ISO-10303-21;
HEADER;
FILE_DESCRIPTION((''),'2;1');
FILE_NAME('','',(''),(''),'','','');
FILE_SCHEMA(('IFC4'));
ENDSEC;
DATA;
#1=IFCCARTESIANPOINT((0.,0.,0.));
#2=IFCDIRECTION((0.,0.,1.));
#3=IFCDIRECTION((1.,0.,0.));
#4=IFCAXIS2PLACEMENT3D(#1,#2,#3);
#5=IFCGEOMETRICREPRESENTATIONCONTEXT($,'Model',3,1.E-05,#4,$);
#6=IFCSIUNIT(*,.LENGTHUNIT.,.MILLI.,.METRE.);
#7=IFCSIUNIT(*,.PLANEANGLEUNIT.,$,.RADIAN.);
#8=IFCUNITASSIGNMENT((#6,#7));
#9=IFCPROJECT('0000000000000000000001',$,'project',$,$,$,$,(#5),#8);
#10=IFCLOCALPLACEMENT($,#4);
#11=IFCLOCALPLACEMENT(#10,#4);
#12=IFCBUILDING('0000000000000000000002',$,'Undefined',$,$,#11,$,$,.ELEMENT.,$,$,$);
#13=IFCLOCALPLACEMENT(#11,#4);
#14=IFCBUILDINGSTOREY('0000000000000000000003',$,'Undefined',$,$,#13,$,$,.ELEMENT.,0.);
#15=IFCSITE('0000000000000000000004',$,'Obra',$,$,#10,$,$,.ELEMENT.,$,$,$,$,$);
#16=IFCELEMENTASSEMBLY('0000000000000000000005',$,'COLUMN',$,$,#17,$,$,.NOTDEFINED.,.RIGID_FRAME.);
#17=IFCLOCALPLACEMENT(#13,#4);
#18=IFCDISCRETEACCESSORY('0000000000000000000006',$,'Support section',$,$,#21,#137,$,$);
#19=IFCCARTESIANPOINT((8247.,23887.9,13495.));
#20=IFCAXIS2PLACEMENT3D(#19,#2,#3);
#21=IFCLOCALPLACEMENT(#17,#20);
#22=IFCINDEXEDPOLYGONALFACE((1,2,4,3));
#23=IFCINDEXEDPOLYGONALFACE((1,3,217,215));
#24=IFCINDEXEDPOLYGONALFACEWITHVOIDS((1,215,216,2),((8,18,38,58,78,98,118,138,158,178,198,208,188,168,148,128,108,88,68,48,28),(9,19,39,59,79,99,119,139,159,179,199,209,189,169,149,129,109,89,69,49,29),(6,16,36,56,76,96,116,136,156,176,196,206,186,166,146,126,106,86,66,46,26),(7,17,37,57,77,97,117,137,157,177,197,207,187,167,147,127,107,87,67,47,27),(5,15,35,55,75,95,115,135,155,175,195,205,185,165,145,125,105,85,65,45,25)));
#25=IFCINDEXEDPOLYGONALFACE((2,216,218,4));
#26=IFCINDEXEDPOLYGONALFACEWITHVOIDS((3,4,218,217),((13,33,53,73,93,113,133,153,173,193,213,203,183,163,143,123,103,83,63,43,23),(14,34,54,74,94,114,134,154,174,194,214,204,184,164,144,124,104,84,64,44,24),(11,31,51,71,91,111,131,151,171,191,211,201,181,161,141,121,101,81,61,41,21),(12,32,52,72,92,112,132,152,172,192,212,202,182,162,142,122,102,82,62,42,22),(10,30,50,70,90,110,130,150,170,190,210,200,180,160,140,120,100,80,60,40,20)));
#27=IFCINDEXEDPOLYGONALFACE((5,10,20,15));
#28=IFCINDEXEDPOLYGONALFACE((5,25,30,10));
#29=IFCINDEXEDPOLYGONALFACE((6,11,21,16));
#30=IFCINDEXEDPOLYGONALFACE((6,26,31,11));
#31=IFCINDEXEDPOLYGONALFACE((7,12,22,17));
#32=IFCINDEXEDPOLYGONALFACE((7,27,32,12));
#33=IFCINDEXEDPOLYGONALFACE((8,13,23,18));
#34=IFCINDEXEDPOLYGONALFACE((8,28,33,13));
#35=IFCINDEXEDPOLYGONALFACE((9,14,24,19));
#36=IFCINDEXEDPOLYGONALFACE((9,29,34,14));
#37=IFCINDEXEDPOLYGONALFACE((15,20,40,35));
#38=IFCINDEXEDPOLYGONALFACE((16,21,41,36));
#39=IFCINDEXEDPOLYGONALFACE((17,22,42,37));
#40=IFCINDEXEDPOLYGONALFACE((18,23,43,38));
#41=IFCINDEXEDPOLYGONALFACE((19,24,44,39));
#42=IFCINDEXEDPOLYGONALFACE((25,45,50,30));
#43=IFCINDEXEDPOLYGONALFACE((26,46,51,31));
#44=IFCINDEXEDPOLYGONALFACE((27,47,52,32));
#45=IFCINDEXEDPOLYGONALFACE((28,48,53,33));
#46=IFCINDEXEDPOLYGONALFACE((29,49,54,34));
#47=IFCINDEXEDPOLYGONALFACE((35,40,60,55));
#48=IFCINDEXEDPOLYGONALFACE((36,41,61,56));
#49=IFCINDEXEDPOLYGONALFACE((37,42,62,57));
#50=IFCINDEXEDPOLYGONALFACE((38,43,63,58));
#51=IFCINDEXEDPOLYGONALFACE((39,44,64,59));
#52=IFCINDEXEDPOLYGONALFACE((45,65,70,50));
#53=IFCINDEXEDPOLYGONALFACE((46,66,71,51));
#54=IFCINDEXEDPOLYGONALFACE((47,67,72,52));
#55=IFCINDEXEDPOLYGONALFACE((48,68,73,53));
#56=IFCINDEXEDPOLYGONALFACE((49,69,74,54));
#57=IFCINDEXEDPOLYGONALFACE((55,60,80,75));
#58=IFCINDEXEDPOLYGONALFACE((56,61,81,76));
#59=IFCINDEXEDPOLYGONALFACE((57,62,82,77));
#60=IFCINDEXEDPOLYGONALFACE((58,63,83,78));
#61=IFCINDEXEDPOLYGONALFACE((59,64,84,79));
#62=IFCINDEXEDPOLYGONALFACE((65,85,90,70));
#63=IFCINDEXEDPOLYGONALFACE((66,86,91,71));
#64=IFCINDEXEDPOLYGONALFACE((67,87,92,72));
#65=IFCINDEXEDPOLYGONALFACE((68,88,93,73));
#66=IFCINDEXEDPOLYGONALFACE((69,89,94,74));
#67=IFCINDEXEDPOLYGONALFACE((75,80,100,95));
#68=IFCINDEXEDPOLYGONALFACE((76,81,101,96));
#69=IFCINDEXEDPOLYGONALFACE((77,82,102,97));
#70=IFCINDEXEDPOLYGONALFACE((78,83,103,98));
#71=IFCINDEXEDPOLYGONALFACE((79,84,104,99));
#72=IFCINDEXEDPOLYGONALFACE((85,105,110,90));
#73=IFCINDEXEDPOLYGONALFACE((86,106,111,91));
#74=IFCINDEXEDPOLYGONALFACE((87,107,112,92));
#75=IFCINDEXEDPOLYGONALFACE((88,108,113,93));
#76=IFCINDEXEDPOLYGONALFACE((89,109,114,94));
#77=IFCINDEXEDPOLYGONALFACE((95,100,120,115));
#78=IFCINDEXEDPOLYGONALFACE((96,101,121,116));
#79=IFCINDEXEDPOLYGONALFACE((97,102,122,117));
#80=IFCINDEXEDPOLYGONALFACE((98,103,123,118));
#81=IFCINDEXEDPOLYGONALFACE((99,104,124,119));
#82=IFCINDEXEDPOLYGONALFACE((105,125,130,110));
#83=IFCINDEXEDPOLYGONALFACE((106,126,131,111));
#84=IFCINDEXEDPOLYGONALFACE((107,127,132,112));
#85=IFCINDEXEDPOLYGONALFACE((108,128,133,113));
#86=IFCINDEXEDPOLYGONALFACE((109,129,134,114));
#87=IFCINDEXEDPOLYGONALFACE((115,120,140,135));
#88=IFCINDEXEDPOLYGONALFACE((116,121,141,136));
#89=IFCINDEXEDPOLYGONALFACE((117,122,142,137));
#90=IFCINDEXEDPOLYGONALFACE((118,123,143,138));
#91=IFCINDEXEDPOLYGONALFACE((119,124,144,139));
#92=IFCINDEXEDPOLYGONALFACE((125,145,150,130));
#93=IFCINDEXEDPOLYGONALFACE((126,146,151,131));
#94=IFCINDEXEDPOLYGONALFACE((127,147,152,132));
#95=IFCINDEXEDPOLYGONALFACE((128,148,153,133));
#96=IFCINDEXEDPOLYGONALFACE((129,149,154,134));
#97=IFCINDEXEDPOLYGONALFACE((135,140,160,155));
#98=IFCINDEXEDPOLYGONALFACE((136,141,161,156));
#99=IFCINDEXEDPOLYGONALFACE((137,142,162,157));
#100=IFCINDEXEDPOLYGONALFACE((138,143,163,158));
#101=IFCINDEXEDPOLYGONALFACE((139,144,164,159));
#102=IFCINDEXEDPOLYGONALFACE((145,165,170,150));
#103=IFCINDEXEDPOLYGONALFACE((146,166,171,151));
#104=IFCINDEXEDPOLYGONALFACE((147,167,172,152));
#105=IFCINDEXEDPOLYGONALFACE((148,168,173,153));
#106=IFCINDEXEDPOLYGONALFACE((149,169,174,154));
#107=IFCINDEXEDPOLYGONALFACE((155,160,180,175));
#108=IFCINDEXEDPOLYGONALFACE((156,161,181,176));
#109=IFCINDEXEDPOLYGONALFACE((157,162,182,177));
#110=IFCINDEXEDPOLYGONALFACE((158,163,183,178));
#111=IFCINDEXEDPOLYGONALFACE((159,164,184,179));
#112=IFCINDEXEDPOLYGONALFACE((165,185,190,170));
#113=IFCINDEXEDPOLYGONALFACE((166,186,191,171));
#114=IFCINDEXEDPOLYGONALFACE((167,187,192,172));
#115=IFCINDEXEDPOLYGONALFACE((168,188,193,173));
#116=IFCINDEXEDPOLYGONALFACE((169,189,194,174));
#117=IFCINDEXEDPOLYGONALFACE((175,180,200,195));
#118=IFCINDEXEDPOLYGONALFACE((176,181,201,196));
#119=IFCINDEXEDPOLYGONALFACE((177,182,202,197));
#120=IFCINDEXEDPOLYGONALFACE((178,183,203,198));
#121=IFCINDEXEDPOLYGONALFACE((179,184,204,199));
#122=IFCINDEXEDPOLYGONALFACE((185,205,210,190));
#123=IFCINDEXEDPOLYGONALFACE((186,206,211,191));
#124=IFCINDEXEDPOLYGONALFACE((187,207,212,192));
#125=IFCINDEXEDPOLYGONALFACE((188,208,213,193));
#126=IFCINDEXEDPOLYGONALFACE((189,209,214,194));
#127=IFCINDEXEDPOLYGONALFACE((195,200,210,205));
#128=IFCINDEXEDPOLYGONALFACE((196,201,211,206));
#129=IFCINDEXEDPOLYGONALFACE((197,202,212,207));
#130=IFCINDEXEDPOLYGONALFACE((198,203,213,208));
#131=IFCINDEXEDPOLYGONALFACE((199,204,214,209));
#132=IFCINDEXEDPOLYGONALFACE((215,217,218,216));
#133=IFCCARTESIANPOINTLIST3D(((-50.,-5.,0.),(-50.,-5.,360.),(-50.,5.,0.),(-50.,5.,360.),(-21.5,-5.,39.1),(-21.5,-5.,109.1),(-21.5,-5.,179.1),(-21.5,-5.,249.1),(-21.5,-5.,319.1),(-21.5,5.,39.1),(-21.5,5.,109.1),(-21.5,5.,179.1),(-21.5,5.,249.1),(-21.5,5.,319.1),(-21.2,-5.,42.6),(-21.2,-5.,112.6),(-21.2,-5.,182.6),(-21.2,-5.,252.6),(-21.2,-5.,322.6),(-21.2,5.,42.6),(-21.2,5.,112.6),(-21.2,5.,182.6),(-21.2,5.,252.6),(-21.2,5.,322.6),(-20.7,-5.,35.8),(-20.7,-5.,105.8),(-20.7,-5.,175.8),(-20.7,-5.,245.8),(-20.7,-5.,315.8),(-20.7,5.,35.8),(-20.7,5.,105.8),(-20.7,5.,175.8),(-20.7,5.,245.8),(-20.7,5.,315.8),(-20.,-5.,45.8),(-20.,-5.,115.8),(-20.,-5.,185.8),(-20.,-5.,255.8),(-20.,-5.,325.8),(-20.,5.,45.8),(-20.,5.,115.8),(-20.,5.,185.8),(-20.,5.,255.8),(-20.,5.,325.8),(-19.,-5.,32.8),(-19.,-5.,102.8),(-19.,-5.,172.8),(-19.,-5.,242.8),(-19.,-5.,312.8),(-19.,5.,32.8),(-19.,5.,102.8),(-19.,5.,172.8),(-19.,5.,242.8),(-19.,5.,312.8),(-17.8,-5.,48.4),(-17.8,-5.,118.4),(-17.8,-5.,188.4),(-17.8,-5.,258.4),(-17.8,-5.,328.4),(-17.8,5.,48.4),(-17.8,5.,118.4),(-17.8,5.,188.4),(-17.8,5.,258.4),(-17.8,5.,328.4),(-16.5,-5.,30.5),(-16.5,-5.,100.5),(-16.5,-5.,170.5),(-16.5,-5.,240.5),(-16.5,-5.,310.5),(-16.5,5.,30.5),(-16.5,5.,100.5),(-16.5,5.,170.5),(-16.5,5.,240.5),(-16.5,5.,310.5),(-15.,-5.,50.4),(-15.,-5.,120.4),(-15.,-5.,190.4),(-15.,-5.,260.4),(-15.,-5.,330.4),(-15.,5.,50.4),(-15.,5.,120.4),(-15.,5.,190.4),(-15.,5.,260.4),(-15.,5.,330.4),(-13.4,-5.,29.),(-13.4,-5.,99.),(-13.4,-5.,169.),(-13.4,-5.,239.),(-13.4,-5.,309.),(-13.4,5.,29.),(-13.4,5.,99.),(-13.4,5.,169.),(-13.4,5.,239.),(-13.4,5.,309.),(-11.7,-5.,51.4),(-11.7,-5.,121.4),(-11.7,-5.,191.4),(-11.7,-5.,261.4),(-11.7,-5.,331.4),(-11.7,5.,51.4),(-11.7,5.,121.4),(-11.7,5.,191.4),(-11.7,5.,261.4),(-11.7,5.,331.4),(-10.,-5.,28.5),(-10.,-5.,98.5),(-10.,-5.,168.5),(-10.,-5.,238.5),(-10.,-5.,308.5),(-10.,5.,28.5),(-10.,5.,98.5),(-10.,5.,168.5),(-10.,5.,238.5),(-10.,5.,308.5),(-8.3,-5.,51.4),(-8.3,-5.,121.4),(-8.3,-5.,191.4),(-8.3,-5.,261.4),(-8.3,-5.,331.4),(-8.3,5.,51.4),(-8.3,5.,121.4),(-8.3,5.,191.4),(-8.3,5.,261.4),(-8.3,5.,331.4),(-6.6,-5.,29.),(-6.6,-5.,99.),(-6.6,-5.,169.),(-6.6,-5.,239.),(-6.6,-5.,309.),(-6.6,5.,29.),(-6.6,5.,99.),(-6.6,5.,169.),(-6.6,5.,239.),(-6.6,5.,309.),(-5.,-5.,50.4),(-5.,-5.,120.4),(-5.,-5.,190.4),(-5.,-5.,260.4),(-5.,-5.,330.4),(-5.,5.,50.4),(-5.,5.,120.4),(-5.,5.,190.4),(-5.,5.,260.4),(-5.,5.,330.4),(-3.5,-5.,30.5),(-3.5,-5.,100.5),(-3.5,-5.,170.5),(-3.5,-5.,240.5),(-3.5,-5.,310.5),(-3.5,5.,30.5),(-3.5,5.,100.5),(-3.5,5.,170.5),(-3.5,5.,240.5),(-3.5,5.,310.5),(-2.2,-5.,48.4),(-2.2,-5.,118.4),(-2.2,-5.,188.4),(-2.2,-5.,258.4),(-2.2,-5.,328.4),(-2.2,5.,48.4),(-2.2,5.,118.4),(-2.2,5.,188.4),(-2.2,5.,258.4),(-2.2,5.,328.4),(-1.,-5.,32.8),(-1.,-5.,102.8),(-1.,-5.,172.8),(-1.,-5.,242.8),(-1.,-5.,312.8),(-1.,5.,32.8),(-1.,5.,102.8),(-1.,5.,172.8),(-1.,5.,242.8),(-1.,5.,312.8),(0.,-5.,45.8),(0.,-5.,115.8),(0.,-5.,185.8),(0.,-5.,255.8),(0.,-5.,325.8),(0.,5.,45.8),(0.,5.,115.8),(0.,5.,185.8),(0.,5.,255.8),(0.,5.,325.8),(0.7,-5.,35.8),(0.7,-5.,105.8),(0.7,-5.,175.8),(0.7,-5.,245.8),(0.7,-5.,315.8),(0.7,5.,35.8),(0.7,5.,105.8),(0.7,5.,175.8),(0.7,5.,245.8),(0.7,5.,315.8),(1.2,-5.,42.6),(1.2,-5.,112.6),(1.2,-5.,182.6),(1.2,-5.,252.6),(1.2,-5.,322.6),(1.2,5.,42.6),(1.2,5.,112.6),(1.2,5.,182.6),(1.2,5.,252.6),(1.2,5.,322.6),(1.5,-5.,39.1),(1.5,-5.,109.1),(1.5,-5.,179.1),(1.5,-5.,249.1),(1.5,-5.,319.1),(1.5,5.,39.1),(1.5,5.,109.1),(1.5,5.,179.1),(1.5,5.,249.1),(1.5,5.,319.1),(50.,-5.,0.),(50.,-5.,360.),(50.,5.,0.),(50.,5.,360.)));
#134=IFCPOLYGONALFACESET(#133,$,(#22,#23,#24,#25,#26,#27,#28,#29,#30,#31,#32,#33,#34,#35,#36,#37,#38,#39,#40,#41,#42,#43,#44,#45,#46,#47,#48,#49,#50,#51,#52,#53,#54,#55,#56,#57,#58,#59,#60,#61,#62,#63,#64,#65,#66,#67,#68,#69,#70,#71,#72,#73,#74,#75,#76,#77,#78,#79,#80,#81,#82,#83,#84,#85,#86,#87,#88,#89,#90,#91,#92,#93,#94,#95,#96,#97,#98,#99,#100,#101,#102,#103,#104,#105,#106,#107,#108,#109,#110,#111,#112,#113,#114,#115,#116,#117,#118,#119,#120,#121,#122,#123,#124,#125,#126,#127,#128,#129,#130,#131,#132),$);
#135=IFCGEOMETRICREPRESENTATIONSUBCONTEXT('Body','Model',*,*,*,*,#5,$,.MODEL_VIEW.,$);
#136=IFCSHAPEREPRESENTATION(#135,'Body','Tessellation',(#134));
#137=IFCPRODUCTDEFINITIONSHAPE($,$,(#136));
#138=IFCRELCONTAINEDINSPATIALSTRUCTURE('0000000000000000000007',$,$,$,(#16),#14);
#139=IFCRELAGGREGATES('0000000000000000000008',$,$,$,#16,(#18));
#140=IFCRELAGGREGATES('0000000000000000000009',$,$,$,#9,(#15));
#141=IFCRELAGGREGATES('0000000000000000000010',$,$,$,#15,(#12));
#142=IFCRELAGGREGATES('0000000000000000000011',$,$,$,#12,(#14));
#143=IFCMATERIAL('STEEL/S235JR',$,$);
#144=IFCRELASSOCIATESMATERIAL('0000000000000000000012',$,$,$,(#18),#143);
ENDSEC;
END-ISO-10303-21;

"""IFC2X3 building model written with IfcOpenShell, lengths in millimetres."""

from ifc_helpers import new_model, si_unit, frame, origin_with_axes, origin_2d_with_axis, place, context, subcontext, project, spatial, rectangle, circle, extrude, source, transform, mapped, material, element, aggregate, save


model = new_model("IFC2X3")

# Units and contexts
model_context = context("Model", 3, precision=1e-05, world=origin_with_axes())
body_context = subcontext(model_context, "Body", "Model", "MODEL_VIEW")
ifc_project = project(units=[si_unit("LENGTHUNIT", "METRE", prefix="MILLI"), si_unit("PLANEANGLEUNIT", "RADIAN")], contexts=[model_context])

# Site, building, storey
site_placement = place(None, origin_with_axes())
site = spatial("IfcSite", under=ifc_project, at=site_placement, Name="Obra", CompositionType="ELEMENT")
building_placement = place(site_placement, origin_with_axes())
building = spatial("IfcBuilding", under=site, at=building_placement, Name="Undefined", CompositionType="ELEMENT")
storey_placement = place(building_placement, origin_with_axes())
storey = spatial("IfcBuildingStorey", under=building, at=storey_placement, Name="Undefined", CompositionType="ELEMENT", Elevation=0.0)

# Element assembly
assembly_1_placement = place(storey_placement, origin_with_axes())
assembly_1 = element("IfcElementAssembly", 1, at=assembly_1_placement, inside=storey, Name="COLUMN", AssemblyPlace="NOTDEFINED", PredefinedType="RIGID_FRAME")
ifc_material_1 = material(Name="STEEL/S235JR")

# Discrete accessory, opening
discrete_accessory_1_placement = place(assembly_1_placement, frame((8247.0, 23887.9, 13495.0), z_axis=(0.0, 0.0, 1.0), x_axis=(1.0, 0.0, 0.0)))
discrete_accessory_1 = element("IfcDiscreteAccessory", 2, at=discrete_accessory_1_placement, material=ifc_material_1, Name="Support section", context=body_context, shape_type="SweptSolid", body=[
    extrude(rectangle(XDim=10.0, YDim=100.0, at=origin_2d_with_axis()), frame((0.0, 0.0, 360.0), z_axis=(0.0, 0.0, -1.0), x_axis=(0.0, 1.0, 0.0)), (0.0, 0.0, 1.0), 360.0),
])
shared_shape_1 = source(origin_with_axes(), body_context, "Body", "SweptSolid", [
    extrude(circle(Radius=11.5, at=origin_2d_with_axis()), frame((0.0, 4.6, 0.0), z_axis=(0.0, 1.0, 0.0), x_axis=(1.0, 0.0, 0.0)), (0.0, 0.0, 1.0), 10.2),
])
opening_1_placement = place(assembly_1_placement, frame((8277.0, 23897.6, 13900.0), z_axis=(-1.0, 0.0, 0.0), x_axis=(0.0, 0.0, -1.0)))
element("IfcOpeningElement", 3, at=opening_1_placement, cuts=discrete_accessory_1, ObjectType="Opening", context=body_context, shape_type="MappedRepresentation", body=[
    mapped(shared_shape_1, transform((85.0, 0.0, 40.0))),
    mapped(shared_shape_1, transform((155.0, 0.0, 40.0))),
    mapped(shared_shape_1, transform((225.0, 0.0, 40.0))),
    mapped(shared_shape_1, transform((295.0, 0.0, 40.0))),
    mapped(shared_shape_1, transform((365.0, 0.0, 40.0))),
])
aggregate(assembly_1, [discrete_accessory_1])

save(model, "model.ifc")
